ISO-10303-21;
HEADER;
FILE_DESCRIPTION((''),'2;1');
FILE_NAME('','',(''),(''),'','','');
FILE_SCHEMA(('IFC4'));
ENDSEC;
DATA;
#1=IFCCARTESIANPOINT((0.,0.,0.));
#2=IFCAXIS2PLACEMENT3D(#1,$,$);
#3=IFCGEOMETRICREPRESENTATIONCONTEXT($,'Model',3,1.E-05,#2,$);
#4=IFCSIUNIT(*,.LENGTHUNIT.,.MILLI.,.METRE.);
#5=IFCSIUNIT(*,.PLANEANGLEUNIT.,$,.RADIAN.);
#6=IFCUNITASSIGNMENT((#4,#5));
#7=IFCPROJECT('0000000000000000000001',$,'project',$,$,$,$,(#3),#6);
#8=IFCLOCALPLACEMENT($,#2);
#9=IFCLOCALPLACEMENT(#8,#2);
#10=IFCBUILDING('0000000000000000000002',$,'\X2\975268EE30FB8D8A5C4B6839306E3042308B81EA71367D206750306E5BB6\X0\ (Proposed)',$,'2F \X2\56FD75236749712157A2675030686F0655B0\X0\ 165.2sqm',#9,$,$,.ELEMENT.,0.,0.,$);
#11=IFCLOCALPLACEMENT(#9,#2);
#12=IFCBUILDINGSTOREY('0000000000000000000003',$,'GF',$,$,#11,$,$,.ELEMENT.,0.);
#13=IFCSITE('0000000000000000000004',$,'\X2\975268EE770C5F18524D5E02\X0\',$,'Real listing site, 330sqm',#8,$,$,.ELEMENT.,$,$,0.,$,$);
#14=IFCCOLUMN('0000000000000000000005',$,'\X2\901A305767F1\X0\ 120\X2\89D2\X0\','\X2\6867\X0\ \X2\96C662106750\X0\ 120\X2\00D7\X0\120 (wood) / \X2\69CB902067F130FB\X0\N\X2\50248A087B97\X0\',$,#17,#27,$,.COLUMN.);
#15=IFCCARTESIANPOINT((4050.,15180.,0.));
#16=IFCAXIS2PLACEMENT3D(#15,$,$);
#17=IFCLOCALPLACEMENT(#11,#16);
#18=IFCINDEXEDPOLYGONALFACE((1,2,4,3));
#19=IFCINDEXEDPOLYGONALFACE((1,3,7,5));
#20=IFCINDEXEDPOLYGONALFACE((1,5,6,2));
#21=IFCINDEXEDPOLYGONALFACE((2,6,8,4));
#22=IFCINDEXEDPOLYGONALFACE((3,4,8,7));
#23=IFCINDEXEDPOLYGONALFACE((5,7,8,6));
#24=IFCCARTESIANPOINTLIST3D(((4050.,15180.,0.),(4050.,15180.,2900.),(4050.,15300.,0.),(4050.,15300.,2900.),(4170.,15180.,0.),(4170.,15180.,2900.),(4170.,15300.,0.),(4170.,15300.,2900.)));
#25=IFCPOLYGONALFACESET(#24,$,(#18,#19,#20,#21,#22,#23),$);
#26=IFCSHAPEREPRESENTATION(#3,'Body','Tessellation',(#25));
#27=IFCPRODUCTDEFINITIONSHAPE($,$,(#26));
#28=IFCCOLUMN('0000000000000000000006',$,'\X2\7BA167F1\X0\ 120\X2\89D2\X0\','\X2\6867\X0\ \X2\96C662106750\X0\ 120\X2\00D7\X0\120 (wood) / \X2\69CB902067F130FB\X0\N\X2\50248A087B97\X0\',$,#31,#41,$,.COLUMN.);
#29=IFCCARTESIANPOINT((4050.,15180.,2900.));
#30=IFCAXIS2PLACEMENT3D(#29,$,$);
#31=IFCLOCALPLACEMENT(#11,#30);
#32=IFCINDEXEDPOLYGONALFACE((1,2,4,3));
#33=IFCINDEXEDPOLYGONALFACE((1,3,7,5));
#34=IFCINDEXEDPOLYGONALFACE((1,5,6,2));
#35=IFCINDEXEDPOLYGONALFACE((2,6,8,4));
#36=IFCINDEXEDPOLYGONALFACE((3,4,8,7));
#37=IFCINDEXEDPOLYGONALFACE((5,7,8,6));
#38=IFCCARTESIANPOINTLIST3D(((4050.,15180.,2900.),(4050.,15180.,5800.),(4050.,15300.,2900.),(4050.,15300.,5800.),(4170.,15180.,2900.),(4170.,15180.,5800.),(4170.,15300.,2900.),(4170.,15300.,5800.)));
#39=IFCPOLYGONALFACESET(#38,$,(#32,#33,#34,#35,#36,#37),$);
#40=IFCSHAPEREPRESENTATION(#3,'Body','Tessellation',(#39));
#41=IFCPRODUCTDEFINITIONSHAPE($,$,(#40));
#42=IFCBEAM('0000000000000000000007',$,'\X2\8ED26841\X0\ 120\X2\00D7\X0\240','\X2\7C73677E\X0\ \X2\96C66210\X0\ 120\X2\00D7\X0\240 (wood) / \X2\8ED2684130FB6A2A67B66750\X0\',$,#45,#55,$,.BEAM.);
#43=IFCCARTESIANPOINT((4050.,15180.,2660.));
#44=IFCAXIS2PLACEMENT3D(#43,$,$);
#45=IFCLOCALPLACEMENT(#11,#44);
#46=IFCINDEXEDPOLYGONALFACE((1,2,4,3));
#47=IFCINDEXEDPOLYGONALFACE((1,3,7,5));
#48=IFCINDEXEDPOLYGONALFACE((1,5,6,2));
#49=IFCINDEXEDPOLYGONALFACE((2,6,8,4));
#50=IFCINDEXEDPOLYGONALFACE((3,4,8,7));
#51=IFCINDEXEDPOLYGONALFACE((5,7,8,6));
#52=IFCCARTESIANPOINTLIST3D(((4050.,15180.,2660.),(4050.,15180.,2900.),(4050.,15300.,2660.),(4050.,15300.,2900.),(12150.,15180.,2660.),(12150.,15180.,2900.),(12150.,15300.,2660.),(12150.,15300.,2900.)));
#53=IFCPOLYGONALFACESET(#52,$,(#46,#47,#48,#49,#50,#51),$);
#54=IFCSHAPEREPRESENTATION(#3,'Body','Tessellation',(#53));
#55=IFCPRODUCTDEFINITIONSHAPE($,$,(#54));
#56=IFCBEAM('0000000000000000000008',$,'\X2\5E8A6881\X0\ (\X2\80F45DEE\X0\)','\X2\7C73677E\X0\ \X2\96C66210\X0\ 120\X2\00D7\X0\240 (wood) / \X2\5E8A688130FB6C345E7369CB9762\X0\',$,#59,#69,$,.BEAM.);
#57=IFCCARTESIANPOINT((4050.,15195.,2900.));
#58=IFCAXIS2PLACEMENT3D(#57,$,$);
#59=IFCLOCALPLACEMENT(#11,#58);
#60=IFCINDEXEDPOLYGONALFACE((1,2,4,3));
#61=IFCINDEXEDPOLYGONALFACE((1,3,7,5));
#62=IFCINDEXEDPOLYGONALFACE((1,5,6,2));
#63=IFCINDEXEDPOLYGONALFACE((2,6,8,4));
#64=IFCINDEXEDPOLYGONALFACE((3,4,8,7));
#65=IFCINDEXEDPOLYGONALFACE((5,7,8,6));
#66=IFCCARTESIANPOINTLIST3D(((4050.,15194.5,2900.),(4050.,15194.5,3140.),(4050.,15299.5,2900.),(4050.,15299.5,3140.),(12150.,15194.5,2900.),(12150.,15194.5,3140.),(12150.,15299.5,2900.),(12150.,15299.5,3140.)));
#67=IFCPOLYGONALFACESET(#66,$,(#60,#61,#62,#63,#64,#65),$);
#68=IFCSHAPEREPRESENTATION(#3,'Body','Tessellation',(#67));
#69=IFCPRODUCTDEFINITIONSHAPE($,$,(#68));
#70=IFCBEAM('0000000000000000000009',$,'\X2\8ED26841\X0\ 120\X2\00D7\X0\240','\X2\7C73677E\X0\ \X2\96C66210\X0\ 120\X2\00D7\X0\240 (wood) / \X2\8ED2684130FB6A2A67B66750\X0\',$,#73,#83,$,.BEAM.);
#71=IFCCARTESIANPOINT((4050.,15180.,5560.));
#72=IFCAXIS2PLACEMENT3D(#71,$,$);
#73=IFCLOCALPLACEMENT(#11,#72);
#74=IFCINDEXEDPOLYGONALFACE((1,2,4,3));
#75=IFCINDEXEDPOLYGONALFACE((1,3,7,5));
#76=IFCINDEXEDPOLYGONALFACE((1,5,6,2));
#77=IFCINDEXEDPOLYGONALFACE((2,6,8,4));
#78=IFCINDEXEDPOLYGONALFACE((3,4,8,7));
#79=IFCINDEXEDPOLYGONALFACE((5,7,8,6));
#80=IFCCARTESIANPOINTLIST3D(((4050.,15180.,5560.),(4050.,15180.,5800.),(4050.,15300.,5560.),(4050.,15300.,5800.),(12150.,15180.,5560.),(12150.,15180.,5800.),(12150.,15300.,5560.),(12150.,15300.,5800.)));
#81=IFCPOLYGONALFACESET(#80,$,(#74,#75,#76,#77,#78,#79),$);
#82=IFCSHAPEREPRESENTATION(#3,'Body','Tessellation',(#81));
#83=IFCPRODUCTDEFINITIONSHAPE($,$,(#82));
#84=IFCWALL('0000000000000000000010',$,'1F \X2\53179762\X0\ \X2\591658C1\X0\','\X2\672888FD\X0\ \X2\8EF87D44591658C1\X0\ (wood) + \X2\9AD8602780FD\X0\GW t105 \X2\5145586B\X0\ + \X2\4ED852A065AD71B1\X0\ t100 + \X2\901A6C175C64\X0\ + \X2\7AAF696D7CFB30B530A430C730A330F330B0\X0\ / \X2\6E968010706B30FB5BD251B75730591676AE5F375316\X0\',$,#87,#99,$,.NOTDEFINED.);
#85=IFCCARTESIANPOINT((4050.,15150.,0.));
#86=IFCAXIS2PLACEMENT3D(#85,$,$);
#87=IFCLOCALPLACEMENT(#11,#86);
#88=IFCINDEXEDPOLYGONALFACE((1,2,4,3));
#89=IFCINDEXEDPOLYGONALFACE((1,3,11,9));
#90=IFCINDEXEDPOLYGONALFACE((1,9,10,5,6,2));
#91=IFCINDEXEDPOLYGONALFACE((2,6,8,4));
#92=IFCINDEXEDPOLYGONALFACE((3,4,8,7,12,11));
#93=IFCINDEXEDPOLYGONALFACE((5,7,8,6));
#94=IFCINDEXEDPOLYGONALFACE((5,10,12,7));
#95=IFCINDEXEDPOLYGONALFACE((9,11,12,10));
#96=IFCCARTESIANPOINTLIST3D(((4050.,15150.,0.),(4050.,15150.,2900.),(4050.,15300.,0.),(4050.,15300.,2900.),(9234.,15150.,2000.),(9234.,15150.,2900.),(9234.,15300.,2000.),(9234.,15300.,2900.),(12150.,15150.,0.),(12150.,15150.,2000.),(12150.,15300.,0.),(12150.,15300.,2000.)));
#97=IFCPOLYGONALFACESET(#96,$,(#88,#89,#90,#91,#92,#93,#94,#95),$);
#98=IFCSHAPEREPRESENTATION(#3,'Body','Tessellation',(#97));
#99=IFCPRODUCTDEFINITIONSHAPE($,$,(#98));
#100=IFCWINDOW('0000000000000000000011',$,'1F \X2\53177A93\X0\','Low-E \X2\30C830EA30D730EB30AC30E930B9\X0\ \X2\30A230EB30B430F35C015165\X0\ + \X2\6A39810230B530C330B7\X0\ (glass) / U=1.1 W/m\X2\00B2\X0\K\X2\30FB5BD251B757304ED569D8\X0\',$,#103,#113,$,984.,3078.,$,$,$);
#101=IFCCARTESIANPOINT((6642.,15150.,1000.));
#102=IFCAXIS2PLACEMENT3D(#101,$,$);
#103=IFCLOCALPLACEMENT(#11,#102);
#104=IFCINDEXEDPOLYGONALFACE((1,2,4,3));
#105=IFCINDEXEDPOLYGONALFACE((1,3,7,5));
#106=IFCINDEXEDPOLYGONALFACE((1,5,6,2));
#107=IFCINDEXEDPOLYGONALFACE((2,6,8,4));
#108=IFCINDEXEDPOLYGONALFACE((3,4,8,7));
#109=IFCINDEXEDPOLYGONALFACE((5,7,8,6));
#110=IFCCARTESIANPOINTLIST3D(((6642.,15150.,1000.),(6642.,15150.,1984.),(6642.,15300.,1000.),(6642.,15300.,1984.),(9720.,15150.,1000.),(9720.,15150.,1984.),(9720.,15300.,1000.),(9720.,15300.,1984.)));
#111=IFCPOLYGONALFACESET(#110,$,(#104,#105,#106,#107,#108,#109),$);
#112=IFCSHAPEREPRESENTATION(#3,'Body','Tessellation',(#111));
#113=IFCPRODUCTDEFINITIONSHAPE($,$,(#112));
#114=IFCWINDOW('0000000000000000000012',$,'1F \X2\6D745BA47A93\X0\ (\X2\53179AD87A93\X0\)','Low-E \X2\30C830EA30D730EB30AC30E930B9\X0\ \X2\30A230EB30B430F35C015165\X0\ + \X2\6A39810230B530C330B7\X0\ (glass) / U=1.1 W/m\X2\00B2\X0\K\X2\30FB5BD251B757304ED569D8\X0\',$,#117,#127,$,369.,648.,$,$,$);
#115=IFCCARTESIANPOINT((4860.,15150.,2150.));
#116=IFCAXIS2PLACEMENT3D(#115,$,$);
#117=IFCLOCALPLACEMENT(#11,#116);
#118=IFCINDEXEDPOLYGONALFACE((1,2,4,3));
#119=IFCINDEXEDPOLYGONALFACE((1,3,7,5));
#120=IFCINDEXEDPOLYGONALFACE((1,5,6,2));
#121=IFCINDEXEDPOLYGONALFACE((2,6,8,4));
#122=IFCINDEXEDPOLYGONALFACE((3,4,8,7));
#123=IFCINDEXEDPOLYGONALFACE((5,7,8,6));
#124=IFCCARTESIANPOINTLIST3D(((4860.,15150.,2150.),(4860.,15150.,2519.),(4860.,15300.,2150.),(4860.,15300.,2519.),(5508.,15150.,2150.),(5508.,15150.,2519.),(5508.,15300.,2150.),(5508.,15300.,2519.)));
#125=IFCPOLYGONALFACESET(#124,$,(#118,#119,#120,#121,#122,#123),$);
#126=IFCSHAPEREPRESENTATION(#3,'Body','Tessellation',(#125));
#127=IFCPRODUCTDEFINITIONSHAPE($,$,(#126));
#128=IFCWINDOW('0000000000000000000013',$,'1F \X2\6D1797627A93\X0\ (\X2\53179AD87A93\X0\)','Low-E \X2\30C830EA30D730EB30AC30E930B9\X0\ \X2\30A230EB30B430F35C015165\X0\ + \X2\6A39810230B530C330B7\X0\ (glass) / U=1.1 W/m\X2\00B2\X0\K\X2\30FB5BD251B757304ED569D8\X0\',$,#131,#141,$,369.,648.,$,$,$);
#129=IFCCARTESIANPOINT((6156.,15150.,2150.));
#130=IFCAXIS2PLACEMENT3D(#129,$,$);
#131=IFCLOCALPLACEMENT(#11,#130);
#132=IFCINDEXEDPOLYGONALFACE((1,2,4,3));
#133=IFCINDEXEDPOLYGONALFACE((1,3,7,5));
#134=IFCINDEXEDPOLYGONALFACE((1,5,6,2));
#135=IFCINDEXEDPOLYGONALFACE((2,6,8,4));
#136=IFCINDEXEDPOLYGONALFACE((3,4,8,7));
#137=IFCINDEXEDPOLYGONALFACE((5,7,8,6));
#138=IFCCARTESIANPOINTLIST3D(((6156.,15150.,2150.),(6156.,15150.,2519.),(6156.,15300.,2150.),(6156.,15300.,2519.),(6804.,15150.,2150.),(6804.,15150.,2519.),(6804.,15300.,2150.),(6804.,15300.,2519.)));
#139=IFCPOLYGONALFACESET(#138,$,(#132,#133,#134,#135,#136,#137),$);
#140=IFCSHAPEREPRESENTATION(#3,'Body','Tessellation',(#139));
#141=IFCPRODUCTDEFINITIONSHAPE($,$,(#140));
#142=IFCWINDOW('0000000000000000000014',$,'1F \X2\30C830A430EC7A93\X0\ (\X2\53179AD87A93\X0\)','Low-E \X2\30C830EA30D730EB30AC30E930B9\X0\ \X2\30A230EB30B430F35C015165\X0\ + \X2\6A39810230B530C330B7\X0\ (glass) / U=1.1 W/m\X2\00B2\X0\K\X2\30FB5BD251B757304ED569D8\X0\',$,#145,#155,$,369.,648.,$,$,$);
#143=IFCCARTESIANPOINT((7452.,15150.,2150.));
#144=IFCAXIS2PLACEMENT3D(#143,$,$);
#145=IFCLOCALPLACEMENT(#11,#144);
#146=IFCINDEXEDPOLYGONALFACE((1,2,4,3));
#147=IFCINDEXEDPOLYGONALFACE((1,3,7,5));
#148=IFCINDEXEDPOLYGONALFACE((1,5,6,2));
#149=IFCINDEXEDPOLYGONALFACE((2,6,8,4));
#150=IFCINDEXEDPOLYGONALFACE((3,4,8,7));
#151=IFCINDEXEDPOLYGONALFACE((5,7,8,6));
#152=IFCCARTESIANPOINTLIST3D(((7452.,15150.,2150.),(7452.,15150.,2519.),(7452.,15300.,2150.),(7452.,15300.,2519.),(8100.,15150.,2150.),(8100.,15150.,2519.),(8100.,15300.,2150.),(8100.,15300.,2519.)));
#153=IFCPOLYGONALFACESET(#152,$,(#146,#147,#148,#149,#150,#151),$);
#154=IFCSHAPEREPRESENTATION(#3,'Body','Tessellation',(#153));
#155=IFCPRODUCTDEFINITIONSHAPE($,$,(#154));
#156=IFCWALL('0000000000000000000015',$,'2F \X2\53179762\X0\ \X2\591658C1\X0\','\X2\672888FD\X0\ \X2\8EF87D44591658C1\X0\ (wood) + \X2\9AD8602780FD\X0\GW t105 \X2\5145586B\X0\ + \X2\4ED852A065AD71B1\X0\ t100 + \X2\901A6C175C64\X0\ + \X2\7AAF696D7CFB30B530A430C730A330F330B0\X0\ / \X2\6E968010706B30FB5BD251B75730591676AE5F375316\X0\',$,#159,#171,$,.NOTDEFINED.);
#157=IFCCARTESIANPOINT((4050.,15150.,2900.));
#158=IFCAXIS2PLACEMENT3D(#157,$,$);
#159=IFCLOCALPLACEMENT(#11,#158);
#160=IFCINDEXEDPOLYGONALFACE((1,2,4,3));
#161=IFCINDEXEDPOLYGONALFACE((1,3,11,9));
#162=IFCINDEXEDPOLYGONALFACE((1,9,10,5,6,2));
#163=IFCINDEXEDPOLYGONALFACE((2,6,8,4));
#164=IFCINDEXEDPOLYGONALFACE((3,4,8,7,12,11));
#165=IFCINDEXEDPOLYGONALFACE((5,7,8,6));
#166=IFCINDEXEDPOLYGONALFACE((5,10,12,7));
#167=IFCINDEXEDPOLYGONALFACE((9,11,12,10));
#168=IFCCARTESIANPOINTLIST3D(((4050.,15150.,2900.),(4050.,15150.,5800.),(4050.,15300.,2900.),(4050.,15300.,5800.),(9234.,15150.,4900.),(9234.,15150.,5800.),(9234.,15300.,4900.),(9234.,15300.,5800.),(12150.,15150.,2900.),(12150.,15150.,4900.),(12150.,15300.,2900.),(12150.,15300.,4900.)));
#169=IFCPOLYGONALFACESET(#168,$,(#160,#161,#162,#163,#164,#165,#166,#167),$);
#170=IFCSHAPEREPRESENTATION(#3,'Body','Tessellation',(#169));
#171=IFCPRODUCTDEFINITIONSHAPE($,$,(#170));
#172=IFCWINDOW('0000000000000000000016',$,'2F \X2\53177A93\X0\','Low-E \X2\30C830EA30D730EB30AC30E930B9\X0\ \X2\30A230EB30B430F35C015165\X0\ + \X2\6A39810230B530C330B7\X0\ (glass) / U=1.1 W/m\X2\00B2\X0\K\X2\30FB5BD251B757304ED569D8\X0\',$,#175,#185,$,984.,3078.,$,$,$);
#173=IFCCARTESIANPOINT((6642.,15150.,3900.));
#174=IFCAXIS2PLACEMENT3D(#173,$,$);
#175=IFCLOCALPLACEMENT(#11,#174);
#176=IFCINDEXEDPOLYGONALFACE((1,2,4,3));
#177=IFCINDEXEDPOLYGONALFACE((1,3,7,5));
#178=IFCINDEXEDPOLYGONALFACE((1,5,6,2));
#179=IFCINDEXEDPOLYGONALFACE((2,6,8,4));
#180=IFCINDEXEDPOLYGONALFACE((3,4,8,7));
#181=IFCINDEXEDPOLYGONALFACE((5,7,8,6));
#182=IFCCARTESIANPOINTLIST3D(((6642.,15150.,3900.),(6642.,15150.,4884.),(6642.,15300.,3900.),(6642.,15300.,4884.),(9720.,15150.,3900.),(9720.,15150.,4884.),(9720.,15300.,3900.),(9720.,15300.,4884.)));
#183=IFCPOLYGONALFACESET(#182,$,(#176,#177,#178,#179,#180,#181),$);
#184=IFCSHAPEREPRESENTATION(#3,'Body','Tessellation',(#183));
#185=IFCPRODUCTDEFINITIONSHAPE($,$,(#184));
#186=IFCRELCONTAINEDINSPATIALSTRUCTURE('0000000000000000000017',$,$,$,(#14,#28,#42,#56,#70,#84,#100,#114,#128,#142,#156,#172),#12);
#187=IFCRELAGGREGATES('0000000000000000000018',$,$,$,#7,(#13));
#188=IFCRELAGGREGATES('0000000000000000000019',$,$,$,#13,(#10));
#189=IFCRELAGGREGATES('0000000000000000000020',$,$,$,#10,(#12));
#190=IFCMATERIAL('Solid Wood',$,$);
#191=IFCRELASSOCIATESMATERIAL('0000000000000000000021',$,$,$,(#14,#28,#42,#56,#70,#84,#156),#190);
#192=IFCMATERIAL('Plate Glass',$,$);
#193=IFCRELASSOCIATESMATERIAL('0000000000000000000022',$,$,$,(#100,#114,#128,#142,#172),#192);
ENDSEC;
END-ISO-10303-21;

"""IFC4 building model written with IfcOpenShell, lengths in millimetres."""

from ifc_helpers import new_model, si_unit, frame, frame_2d, origin, place, context, project, spatial, rectangle, extrude, material, element, fill, save


model = new_model("IFC4")

# Units and contexts
model_context = context("Model", 3, precision=1e-05, world=origin())
ifc_project = project(units=[si_unit("LENGTHUNIT", "METRE", prefix="MILLI"), si_unit("PLANEANGLEUNIT", "RADIAN")], contexts=[model_context])

# Site, building, storey
site_placement = place(None, origin())
site = spatial("IfcSite", under=ifc_project, at=site_placement, Name="青森県弘前市", ObjectType="Real listing site, 330sqm", CompositionType="ELEMENT", RefElevation=0.0)
building_placement = place(site_placement, origin())
building = spatial("IfcBuilding", under=site, at=building_placement, Name="青森・越屋根のある自然素材の家 (Proposed)", ObjectType="2F 国産杉無垢材と漆喰 165.2sqm", CompositionType="ELEMENT", ElevationOfRefHeight=0.0, ElevationOfTerrain=0.0)
storey_placement = place(building_placement, origin())
storey = spatial("IfcBuildingStorey", under=building, at=storey_placement, Name="GF", CompositionType="ELEMENT", Elevation=0.0)

# Columns
ifc_material_1 = material(Name="Solid Wood")
column_1_placement = place(storey_placement, frame((4050.0, 15180.0, 0.0)))
element("IfcColumn", 1, at=column_1_placement, inside=storey, material=ifc_material_1, Name="通し柱 120角", Description="桧 集成材 120×120 (wood) / 構造柱・N値計算", PredefinedType="COLUMN", context=model_context, shape_type="SweptSolid", body=[
    extrude(rectangle(XDim=120.0, YDim=120.0, at=frame_2d((60.0, 60.0))), frame((4050.0, 15180.0, 0.0)), (0.0, 0.0, 1.0), 2900.0),
])
column_2_placement = place(storey_placement, frame((4050.0, 15180.0, 2900.0)))
element("IfcColumn", 2, at=column_2_placement, inside=storey, material=ifc_material_1, Name="管柱 120角", Description="桧 集成材 120×120 (wood) / 構造柱・N値計算", PredefinedType="COLUMN", context=model_context, shape_type="SweptSolid", body=[
    extrude(rectangle(XDim=120.0, YDim=120.0, at=frame_2d((60.0, 60.0))), frame((4050.0, 15180.0, 2900.0)), (0.0, 0.0, 1.0), 2900.0),
])

# Beams
beam_1_placement = place(storey_placement, frame((4050.0, 15180.0, 2660.0)))
element("IfcBeam", 3, at=beam_1_placement, inside=storey, material=ifc_material_1, Name="軒桁 120×240", Description="米松 集成 120×240 (wood) / 軒桁・横架材", PredefinedType="BEAM", context=model_context, shape_type="SweptSolid", body=[
    extrude(rectangle(XDim=8100.0, YDim=120.0, at=frame_2d((4050.0, 60.0))), frame((4050.0, 15180.0, 2660.0)), (0.0, 0.0, 1.0), 240.0),
])
beam_2_placement = place(storey_placement, frame((4050.0, 15195.0, 2900.0)))
element("IfcBeam", 4, at=beam_2_placement, inside=storey, material=ifc_material_1, Name="床梁 (胴差)", Description="米松 集成 120×240 (wood) / 床梁・水平構面", PredefinedType="BEAM", context=model_context, shape_type="SweptSolid", body=[
    extrude(rectangle(XDim=8100.0, YDim=105.0, at=frame_2d((4050.0, 52.0))), frame((4050.0, 15195.0, 2900.0)), (0.0, 0.0, 1.0), 240.0),
])
beam_3_placement = place(storey_placement, frame((4050.0, 15180.0, 5560.0)))
element("IfcBeam", 5, at=beam_3_placement, inside=storey, material=ifc_material_1, Name="軒桁 120×240", Description="米松 集成 120×240 (wood) / 軒桁・横架材", PredefinedType="BEAM", context=model_context, shape_type="SweptSolid", body=[
    extrude(rectangle(XDim=8100.0, YDim=120.0, at=frame_2d((4050.0, 60.0))), frame((4050.0, 15180.0, 5560.0)), (0.0, 0.0, 1.0), 240.0),
])

# Wall, openings, windows
wall_1_placement = place(storey_placement, frame((4050.0, 15150.0, 0.0)))
wall_1 = element("IfcWall", 6, at=wall_1_placement, inside=storey, material=ifc_material_1, Name="1F 北面 外壁", Description="木製 軸組外壁 (wood) + 高性能GW t105 充填 + 付加断熱 t100 + 通気層 + 窯業系サイディング / 準耐火・寒冷地外皮強化", PredefinedType="NOTDEFINED", context=model_context, shape_type="SweptSolid", body=[
    extrude(rectangle(XDim=8100.0, YDim=150.0, at=frame_2d((4050.0, 75.0))), frame((4050.0, 15150.0, 0.0)), (0.0, 0.0, 1.0), 2900.0),
])
opening_1_placement = place(storey_placement, frame((6642.0, 15150.0, 1000.0)))
opening_1 = element("IfcOpeningElement", 7, at=opening_1_placement, cuts=wall_1, PredefinedType="NOTDEFINED", context=model_context, shape_type="SweptSolid", body=[
    extrude(rectangle(XDim=3078.0, YDim=150.0, at=frame_2d((1539.0, 75.0))), frame((6642.0, 15150.0, 1000.0)), (0.0, 0.0, 1.0), 984.0),
])
opening_2_placement = place(storey_placement, frame((4860.0, 15150.0, 2150.0)))
opening_2 = element("IfcOpeningElement", 8, at=opening_2_placement, cuts=wall_1, PredefinedType="NOTDEFINED", context=model_context, shape_type="SweptSolid", body=[
    extrude(rectangle(XDim=648.0, YDim=150.0, at=frame_2d((324.0, 75.0))), frame((4860.0, 15150.0, 2150.0)), (0.0, 0.0, 1.0), 369.0),
])
opening_3_placement = place(storey_placement, frame((6156.0, 15150.0, 2150.0)))
opening_3 = element("IfcOpeningElement", 9, at=opening_3_placement, cuts=wall_1, PredefinedType="NOTDEFINED", context=model_context, shape_type="SweptSolid", body=[
    extrude(rectangle(XDim=648.0, YDim=150.0, at=frame_2d((324.0, 75.0))), frame((6156.0, 15150.0, 2150.0)), (0.0, 0.0, 1.0), 369.0),
])
opening_4_placement = place(storey_placement, frame((7452.0, 15150.0, 2150.0)))
opening_4 = element("IfcOpeningElement", 10, at=opening_4_placement, cuts=wall_1, PredefinedType="NOTDEFINED", context=model_context, shape_type="SweptSolid", body=[
    extrude(rectangle(XDim=648.0, YDim=150.0, at=frame_2d((324.0, 75.0))), frame((7452.0, 15150.0, 2150.0)), (0.0, 0.0, 1.0), 369.0),
])
ifc_material_2 = material(Name="Plate Glass")
window_1_placement = place(storey_placement, frame((6642.0, 15150.0, 1000.0)))
window_1 = element("IfcWindow", 11, at=window_1_placement, inside=storey, material=ifc_material_2, Name="1F 北窓", Description="Low-E トリプルガラス アルゴン封入 + 樹脂サッシ (glass) / U=1.1 W/m²K・寒冷地仕様", OverallHeight=984.0, OverallWidth=3078.0, context=model_context, shape_type="SweptSolid", body=[
    extrude(rectangle(XDim=3078.0, YDim=150.0, at=frame_2d((1539.0, 75.0))), frame((6642.0, 15150.0, 1000.0)), (0.0, 0.0, 1.0), 984.0),
])
fill(opening_1, window_1)
window_2_placement = place(storey_placement, frame((4860.0, 15150.0, 2150.0)))
window_2 = element("IfcWindow", 12, at=window_2_placement, inside=storey, material=ifc_material_2, Name="1F 浴室窓 (北高窓)", Description="Low-E トリプルガラス アルゴン封入 + 樹脂サッシ (glass) / U=1.1 W/m²K・寒冷地仕様", OverallHeight=369.0, OverallWidth=648.0, context=model_context, shape_type="SweptSolid", body=[
    extrude(rectangle(XDim=648.0, YDim=150.0, at=frame_2d((324.0, 75.0))), frame((4860.0, 15150.0, 2150.0)), (0.0, 0.0, 1.0), 369.0),
])
fill(opening_2, window_2)
window_3_placement = place(storey_placement, frame((6156.0, 15150.0, 2150.0)))
window_3 = element("IfcWindow", 13, at=window_3_placement, inside=storey, material=ifc_material_2, Name="1F 洗面窓 (北高窓)", Description="Low-E トリプルガラス アルゴン封入 + 樹脂サッシ (glass) / U=1.1 W/m²K・寒冷地仕様", OverallHeight=369.0, OverallWidth=648.0, context=model_context, shape_type="SweptSolid", body=[
    extrude(rectangle(XDim=648.0, YDim=150.0, at=frame_2d((324.0, 75.0))), frame((6156.0, 15150.0, 2150.0)), (0.0, 0.0, 1.0), 369.0),
])
fill(opening_3, window_3)
window_4_placement = place(storey_placement, frame((7452.0, 15150.0, 2150.0)))
window_4 = element("IfcWindow", 14, at=window_4_placement, inside=storey, material=ifc_material_2, Name="1F トイレ窓 (北高窓)", Description="Low-E トリプルガラス アルゴン封入 + 樹脂サッシ (glass) / U=1.1 W/m²K・寒冷地仕様", OverallHeight=369.0, OverallWidth=648.0, context=model_context, shape_type="SweptSolid", body=[
    extrude(rectangle(XDim=648.0, YDim=150.0, at=frame_2d((324.0, 75.0))), frame((7452.0, 15150.0, 2150.0)), (0.0, 0.0, 1.0), 369.0),
])
fill(opening_4, window_4)

# Wall, opening, window
wall_2_placement = place(storey_placement, frame((4050.0, 15150.0, 2900.0)))
wall_2 = element("IfcWall", 15, at=wall_2_placement, inside=storey, material=ifc_material_1, Name="2F 北面 外壁", Description="木製 軸組外壁 (wood) + 高性能GW t105 充填 + 付加断熱 t100 + 通気層 + 窯業系サイディング / 準耐火・寒冷地外皮強化", PredefinedType="NOTDEFINED", context=model_context, shape_type="SweptSolid", body=[
    extrude(rectangle(XDim=8100.0, YDim=150.0, at=frame_2d((4050.0, 75.0))), frame((4050.0, 15150.0, 2900.0)), (0.0, 0.0, 1.0), 2900.0),
])
opening_5_placement = place(storey_placement, frame((6642.0, 15150.0, 3900.0)))
opening_5 = element("IfcOpeningElement", 16, at=opening_5_placement, cuts=wall_2, PredefinedType="NOTDEFINED", context=model_context, shape_type="SweptSolid", body=[
    extrude(rectangle(XDim=3078.0, YDim=150.0, at=frame_2d((1539.0, 75.0))), frame((6642.0, 15150.0, 3900.0)), (0.0, 0.0, 1.0), 984.0),
])
window_5_placement = place(storey_placement, frame((6642.0, 15150.0, 3900.0)))
window_5 = element("IfcWindow", 17, at=window_5_placement, inside=storey, material=ifc_material_2, Name="2F 北窓", Description="Low-E トリプルガラス アルゴン封入 + 樹脂サッシ (glass) / U=1.1 W/m²K・寒冷地仕様", OverallHeight=984.0, OverallWidth=3078.0, context=model_context, shape_type="SweptSolid", body=[
    extrude(rectangle(XDim=3078.0, YDim=150.0, at=frame_2d((1539.0, 75.0))), frame((6642.0, 15150.0, 3900.0)), (0.0, 0.0, 1.0), 984.0),
])
fill(opening_5, window_5)

save(model, "model.ifc")
